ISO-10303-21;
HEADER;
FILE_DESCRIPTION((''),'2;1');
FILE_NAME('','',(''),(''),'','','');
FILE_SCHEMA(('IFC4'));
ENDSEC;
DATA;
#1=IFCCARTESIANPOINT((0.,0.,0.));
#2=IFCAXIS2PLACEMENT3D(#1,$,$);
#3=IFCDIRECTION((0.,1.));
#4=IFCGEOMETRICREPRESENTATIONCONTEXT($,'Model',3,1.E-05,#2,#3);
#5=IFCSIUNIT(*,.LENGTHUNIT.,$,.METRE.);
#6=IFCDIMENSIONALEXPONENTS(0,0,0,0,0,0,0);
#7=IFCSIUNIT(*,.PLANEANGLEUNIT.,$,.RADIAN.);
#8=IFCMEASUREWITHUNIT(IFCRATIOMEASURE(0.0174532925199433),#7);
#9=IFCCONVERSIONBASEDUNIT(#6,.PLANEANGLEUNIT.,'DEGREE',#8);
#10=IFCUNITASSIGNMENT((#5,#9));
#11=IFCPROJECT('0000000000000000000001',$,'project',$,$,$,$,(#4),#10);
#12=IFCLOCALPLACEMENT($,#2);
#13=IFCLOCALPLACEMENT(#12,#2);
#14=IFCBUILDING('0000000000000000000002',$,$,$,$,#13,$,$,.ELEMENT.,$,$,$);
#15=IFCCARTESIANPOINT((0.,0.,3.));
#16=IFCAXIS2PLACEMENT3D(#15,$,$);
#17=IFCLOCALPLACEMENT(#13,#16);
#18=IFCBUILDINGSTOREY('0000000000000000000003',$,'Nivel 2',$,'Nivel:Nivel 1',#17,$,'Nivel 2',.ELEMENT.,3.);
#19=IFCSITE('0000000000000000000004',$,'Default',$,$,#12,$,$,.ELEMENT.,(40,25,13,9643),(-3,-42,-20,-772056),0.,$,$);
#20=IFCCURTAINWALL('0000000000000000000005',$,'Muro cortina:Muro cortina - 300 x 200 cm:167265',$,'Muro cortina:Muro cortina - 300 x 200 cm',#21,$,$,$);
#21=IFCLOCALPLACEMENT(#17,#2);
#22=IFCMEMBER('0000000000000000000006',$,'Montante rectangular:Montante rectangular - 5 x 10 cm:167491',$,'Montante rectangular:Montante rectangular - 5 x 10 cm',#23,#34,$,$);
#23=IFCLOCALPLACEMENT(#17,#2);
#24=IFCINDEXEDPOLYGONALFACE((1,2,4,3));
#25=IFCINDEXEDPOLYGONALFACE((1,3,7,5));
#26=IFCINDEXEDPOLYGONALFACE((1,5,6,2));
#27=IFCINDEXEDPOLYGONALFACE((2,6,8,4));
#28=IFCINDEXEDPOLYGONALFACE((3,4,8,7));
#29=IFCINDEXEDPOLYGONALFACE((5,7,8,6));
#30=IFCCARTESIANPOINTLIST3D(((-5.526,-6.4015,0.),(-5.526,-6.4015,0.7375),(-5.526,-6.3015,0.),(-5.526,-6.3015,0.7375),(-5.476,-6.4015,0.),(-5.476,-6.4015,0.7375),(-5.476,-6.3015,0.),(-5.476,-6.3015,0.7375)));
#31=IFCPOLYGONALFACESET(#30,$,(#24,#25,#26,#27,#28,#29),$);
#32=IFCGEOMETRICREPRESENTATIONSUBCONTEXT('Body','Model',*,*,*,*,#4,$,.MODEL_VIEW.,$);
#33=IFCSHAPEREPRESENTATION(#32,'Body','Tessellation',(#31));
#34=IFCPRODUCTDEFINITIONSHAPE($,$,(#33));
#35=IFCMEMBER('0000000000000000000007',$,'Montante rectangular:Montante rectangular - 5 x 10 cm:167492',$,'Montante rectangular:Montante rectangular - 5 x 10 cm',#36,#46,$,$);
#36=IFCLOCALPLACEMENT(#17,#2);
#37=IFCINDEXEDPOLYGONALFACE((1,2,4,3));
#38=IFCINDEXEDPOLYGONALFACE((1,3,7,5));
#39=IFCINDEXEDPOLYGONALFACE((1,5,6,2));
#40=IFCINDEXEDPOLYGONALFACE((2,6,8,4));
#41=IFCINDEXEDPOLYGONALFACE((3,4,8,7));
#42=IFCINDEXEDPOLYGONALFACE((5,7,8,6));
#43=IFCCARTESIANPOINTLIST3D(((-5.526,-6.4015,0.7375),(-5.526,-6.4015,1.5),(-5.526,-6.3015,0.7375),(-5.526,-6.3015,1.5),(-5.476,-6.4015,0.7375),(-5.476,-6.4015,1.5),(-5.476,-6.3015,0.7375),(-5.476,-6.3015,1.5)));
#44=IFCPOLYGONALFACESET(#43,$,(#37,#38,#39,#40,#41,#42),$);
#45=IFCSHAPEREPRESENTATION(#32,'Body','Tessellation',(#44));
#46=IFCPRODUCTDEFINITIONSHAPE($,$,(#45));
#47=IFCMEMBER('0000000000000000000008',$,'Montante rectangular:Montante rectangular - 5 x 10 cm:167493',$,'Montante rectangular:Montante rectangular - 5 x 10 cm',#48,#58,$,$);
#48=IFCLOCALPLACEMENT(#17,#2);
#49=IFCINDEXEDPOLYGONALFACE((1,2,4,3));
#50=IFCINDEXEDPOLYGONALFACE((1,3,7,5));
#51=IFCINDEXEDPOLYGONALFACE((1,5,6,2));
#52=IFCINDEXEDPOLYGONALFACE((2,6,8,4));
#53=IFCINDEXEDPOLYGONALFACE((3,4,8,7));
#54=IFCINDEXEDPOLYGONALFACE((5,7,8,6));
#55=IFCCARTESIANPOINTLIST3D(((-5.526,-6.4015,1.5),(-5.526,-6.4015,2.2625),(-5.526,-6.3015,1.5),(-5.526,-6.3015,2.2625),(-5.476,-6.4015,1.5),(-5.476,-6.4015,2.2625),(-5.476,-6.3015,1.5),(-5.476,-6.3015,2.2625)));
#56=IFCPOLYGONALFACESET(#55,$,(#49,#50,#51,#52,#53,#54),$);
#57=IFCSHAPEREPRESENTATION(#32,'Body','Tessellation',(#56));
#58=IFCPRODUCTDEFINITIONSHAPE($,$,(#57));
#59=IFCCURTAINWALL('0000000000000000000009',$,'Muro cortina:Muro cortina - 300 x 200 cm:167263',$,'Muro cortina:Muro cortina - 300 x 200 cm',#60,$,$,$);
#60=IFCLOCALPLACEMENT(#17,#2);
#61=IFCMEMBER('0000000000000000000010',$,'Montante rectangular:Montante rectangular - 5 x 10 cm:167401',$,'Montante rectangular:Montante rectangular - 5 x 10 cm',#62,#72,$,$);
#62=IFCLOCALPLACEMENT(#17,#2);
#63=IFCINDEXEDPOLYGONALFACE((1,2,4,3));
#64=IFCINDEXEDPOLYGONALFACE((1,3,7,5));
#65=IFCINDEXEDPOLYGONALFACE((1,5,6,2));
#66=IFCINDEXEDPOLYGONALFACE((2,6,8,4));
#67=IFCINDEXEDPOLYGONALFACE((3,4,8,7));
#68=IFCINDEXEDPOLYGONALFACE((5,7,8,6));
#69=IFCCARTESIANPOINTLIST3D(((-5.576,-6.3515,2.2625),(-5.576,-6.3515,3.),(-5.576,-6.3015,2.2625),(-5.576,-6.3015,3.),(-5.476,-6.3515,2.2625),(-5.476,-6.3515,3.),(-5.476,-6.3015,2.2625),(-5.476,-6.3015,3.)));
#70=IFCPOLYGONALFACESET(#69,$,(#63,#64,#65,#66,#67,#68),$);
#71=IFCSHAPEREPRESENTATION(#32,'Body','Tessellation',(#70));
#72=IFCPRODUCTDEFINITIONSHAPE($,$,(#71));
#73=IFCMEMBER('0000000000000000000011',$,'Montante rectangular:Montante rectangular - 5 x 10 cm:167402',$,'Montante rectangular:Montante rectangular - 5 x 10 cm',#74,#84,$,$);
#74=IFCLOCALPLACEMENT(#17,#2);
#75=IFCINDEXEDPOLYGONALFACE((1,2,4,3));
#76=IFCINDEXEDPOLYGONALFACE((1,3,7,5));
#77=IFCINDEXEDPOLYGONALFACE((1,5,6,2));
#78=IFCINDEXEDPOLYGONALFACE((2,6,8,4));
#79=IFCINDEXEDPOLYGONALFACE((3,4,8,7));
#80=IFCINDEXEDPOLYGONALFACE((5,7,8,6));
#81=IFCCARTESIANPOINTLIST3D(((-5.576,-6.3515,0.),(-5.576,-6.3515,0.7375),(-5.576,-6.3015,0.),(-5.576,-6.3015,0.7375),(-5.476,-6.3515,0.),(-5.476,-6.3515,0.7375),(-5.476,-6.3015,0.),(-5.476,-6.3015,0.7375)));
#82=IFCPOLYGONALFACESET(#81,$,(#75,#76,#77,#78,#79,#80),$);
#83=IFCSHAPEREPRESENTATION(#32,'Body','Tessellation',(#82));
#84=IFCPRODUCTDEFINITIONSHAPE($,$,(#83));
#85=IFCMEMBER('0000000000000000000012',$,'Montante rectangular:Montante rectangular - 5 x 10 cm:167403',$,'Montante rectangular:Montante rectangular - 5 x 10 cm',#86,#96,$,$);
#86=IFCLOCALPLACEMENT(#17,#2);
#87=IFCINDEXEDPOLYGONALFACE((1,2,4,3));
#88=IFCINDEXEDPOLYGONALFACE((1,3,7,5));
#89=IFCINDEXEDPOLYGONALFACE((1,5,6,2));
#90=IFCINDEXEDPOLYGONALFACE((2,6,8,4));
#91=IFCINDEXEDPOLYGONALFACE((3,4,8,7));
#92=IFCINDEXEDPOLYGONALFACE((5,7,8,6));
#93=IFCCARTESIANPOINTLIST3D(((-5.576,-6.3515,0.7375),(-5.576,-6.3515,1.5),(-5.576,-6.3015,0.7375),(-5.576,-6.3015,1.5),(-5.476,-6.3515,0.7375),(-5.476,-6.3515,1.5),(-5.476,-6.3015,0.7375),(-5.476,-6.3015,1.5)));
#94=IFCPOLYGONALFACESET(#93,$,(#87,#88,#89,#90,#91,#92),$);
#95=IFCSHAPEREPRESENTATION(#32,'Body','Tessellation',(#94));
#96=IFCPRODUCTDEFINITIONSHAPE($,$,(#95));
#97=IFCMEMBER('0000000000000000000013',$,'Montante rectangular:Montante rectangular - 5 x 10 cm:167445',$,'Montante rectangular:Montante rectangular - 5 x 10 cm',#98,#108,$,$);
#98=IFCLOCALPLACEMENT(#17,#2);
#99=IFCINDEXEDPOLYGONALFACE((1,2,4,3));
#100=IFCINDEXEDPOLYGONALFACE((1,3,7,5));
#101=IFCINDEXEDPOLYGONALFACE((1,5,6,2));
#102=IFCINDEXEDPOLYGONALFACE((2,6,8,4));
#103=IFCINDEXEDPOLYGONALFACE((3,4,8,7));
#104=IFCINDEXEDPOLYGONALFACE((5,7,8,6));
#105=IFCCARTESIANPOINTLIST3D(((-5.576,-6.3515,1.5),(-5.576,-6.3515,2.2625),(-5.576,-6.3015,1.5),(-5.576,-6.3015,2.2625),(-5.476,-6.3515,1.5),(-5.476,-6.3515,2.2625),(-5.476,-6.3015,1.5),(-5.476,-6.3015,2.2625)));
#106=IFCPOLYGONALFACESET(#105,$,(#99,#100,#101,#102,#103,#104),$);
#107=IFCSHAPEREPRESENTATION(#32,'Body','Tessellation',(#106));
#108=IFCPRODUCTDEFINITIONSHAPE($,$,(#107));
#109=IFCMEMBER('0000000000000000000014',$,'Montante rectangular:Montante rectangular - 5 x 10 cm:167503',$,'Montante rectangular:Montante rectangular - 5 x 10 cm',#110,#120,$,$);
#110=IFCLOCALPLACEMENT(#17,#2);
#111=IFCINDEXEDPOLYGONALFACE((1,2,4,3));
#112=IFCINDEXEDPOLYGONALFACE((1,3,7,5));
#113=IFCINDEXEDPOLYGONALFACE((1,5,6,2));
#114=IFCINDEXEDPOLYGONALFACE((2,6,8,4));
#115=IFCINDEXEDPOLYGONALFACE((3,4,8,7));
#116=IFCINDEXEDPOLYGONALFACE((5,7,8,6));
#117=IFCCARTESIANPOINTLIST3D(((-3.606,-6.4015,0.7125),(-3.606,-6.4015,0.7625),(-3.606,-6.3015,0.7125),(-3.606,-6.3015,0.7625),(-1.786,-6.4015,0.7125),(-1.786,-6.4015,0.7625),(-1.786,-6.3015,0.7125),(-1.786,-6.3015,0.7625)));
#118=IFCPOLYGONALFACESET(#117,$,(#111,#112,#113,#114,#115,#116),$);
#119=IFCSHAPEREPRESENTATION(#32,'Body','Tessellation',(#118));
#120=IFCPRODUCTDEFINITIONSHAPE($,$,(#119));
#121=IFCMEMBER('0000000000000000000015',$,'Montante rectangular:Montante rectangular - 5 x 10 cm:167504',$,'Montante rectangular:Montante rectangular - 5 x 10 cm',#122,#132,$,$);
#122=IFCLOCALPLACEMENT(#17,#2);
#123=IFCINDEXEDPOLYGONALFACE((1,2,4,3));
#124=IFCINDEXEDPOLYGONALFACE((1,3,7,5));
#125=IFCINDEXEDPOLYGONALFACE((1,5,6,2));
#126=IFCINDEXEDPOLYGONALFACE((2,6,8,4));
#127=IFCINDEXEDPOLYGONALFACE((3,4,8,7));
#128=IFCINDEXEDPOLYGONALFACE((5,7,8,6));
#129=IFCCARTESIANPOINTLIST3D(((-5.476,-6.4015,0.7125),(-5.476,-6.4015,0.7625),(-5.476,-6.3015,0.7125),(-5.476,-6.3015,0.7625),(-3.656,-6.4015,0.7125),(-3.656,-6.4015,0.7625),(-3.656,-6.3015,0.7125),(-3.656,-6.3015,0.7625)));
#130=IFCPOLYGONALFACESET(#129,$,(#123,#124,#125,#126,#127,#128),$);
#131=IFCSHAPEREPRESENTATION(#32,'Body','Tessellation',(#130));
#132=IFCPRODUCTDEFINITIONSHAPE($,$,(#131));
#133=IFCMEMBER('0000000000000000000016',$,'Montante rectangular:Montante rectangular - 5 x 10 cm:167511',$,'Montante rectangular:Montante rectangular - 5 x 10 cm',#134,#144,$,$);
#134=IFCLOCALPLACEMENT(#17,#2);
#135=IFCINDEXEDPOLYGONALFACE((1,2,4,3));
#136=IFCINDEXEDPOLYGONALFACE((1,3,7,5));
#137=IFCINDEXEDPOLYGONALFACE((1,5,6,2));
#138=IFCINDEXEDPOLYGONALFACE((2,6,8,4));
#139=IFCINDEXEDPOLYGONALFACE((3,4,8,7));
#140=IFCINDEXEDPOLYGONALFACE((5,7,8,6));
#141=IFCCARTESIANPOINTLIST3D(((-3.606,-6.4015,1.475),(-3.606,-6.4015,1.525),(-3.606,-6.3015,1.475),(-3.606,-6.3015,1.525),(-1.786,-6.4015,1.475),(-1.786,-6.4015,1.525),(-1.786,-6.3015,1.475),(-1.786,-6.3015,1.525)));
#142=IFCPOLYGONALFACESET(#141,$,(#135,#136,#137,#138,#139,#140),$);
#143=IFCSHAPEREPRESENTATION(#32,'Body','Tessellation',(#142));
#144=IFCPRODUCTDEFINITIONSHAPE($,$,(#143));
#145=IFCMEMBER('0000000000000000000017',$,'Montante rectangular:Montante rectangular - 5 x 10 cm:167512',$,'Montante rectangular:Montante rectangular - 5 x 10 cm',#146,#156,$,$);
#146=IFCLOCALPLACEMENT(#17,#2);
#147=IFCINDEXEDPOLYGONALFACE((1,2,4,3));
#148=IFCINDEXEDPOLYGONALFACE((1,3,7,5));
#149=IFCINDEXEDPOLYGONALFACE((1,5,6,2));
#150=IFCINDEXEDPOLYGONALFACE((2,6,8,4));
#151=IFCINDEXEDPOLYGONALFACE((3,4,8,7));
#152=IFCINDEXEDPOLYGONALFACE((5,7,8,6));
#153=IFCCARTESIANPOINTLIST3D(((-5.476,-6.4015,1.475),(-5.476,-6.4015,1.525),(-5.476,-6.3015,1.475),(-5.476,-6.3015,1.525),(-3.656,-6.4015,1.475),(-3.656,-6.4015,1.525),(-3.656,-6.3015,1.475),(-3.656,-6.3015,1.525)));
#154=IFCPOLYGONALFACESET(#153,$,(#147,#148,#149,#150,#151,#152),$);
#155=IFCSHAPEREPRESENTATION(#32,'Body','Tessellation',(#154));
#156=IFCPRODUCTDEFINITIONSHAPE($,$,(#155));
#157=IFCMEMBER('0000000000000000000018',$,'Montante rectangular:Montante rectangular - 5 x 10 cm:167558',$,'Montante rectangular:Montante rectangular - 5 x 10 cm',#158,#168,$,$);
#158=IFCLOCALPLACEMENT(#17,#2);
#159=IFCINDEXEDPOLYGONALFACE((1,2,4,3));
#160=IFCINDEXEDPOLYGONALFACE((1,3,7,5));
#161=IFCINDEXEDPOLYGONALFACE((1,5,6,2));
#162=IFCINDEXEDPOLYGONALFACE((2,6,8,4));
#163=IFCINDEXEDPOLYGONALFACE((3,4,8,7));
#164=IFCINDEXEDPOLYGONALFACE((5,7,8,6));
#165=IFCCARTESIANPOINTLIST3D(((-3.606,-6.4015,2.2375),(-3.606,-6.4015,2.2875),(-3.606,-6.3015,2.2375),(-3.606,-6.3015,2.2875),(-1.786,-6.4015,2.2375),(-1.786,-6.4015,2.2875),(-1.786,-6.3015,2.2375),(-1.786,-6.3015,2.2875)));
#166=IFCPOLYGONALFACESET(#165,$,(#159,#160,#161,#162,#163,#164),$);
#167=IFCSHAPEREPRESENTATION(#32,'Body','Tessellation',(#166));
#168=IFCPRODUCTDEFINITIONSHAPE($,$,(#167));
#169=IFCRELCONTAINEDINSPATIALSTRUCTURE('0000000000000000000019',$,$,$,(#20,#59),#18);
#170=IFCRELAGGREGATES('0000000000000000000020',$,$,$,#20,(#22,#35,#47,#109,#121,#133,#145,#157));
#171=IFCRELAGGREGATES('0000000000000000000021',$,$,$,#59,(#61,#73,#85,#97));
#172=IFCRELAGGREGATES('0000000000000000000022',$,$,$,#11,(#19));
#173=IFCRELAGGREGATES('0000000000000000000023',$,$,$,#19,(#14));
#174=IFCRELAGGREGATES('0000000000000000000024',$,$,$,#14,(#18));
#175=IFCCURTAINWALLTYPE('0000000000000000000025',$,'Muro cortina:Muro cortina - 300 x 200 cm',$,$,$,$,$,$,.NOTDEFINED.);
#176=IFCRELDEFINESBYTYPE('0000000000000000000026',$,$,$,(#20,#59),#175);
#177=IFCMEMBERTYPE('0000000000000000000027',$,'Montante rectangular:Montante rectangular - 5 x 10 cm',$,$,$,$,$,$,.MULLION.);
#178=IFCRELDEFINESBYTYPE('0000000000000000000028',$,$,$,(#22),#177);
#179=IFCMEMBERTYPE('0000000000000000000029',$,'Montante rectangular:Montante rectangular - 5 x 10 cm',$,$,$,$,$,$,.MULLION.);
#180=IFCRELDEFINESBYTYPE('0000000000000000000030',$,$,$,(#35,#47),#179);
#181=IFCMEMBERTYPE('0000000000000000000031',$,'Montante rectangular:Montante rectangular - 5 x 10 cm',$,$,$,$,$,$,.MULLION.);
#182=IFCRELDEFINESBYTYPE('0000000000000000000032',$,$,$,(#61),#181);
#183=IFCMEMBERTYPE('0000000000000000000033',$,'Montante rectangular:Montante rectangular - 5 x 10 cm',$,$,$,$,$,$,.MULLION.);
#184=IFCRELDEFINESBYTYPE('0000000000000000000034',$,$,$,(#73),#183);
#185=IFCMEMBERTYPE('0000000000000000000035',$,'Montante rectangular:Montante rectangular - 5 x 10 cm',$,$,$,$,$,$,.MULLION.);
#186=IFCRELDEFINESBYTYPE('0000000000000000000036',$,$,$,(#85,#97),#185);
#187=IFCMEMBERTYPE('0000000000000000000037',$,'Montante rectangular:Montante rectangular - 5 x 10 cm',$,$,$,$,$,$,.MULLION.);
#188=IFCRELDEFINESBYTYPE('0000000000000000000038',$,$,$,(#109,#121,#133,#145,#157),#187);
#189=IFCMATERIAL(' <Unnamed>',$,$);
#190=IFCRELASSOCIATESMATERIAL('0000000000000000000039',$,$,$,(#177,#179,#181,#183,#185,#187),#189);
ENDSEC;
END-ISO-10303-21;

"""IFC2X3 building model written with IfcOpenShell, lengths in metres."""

from ifc_helpers import new_model, entity, si_unit, converted_unit, direction, frame, origin, origin_2d_with_axis, place, context, subcontext, project, spatial, rectangle, extrude, source, transform, mapped, material, type_object, type_shapes, element, aggregate, save


model = new_model("IFC2X3")

# Units and contexts
model_context = context("Model", 3, precision=1e-05, world=origin(), true_north=direction((0.0, 1.0)))
body_context = subcontext(model_context, "Body", "Model", "MODEL_VIEW")
ifc_project = project(units=[si_unit("LENGTHUNIT", "METRE"), converted_unit("PLANEANGLEUNIT", "DEGREE", entity("IfcRatioMeasure", 0.0174532925199433), si_unit("PLANEANGLEUNIT", "RADIAN"), dimensions=[0, 0, 0, 0, 0, 0, 0])], contexts=[model_context])

# Site, building, storey
site_placement = place(None, origin())
site = spatial("IfcSite", under=ifc_project, at=site_placement, Name="Default", CompositionType="ELEMENT", RefLatitude=(40, 25, 13, 9643), RefLongitude=(-3, -42, -20, -772056), RefElevation=0.0)
building_placement = place(site_placement, origin())
building = spatial("IfcBuilding", under=site, at=building_placement, CompositionType="ELEMENT")
storey_placement = place(building_placement, frame((0.0, 0.0, 3.0)))
storey = spatial("IfcBuildingStorey", under=building, at=storey_placement, Name="Nivel 2", ObjectType="Nivel:Nivel 1", LongName="Nivel 2", CompositionType="ELEMENT", Elevation=3.0)

# Curtain walls, members
curtain_wall_type = type_object("IfcCurtainWallType", Name="Muro cortina:Muro cortina - 300 x 200 cm", PredefinedType="NOTDEFINED")
curtain_wall_1_placement = place(storey_placement, frame((0.0, 0.0, -3.0)))
curtain_wall_1 = element("IfcCurtainWall", 1, at=curtain_wall_1_placement, inside=storey, type_object=curtain_wall_type, Name="Muro cortina:Muro cortina - 300 x 200 cm:167265", ObjectType="Muro cortina:Muro cortina - 300 x 200 cm")
ifc_material_1 = material(Name=" <Unnamed>")
member_type_1 = type_object("IfcMemberType", Name="Montante rectangular:Montante rectangular - 5 x 10 cm", PredefinedType="MULLION", material=ifc_material_1)
shared_shape_1 = source(origin(), body_context, "Body", "SweptSolid", [
    extrude(rectangle(XDim=0.1, YDim=0.05, at=origin_2d_with_axis()), frame((-0.025, 0.0, -0.7375), z_axis=(0.0, 0.0, 1.0), x_axis=(0.0, -1.0, 0.0)), (0.0, 0.0, 1.0), 0.7375),
])
type_shapes(member_type_1, [shared_shape_1])
member_1_placement = place(storey_placement, frame((-5.526, -6.3515, 0.0), z_axis=(0.0, 0.0, -1.0), x_axis=(-1.0, 0.0, 0.0)))
member_1 = element("IfcMember", 2, at=member_1_placement, type_object=member_type_1, Name="Montante rectangular:Montante rectangular - 5 x 10 cm:167491", ObjectType="Montante rectangular:Montante rectangular - 5 x 10 cm", context=body_context, shape_type="MappedRepresentation", body=[
    mapped(shared_shape_1, transform((0.0, 0.0, 0.0), scale=1.0)),
])
member_type_2 = type_object("IfcMemberType", Name="Montante rectangular:Montante rectangular - 5 x 10 cm", PredefinedType="MULLION", material=ifc_material_1)
shared_shape_2 = source(origin(), body_context, "Body", "SweptSolid", [
    extrude(rectangle(XDim=0.1, YDim=0.05, at=origin_2d_with_axis()), frame((-0.025, 0.0, -0.7625), z_axis=(0.0, 0.0, 1.0), x_axis=(0.0, -1.0, 0.0)), (0.0, 0.0, 1.0), 0.7625),
])
type_shapes(member_type_2, [shared_shape_2])
member_2_placement = place(storey_placement, frame((-5.526, -6.3515, 0.7375), z_axis=(0.0, 0.0, -1.0), x_axis=(-1.0, 0.0, 0.0)))
member_2 = element("IfcMember", 3, at=member_2_placement, type_object=member_type_2, Name="Montante rectangular:Montante rectangular - 5 x 10 cm:167492", ObjectType="Montante rectangular:Montante rectangular - 5 x 10 cm", context=body_context, shape_type="MappedRepresentation", body=[
    mapped(shared_shape_2, transform((0.0, 0.0, 0.0), scale=1.0)),
])
member_3_placement = place(storey_placement, frame((-5.526, -6.3515, 1.5), z_axis=(0.0, 0.0, -1.0), x_axis=(-1.0, 0.0, 0.0)))
member_3 = element("IfcMember", 4, at=member_3_placement, type_object=member_type_2, Name="Montante rectangular:Montante rectangular - 5 x 10 cm:167493", ObjectType="Montante rectangular:Montante rectangular - 5 x 10 cm", context=body_context, shape_type="MappedRepresentation", body=[
    mapped(shared_shape_2, transform((0.0, 0.0, 0.0), scale=1.0)),
])
curtain_wall_2_placement = place(storey_placement, frame((0.0, 0.0, -3.0)))
curtain_wall_2 = element("IfcCurtainWall", 5, at=curtain_wall_2_placement, inside=storey, type_object=curtain_wall_type, Name="Muro cortina:Muro cortina - 300 x 200 cm:167263", ObjectType="Muro cortina:Muro cortina - 300 x 200 cm")
member_type_3 = type_object("IfcMemberType", Name="Montante rectangular:Montante rectangular - 5 x 10 cm", PredefinedType="MULLION", material=ifc_material_1)
shared_shape_3 = source(origin(), body_context, "Body", "SweptSolid", [
    extrude(rectangle(XDim=0.1, YDim=0.05, at=origin_2d_with_axis()), frame((-0.025, 0.0, -0.7375), z_axis=(0.0, 0.0, 1.0), x_axis=(0.0, -1.0, 0.0)), (0.0, 0.0, 1.0), 0.7375),
])
type_shapes(member_type_3, [shared_shape_3])
member_4_placement = place(storey_placement, frame((-5.526, -6.3515, 3.0), z_axis=(0.0, 0.0, 1.0), x_axis=(0.0, -1.0, 0.0)))
member_4 = element("IfcMember", 6, at=member_4_placement, type_object=member_type_3, Name="Montante rectangular:Montante rectangular - 5 x 10 cm:167401", ObjectType="Montante rectangular:Montante rectangular - 5 x 10 cm", context=body_context, shape_type="MappedRepresentation", body=[
    mapped(shared_shape_3, transform((0.0, 0.0, 0.0), scale=1.0)),
])
member_type_4 = type_object("IfcMemberType", Name="Montante rectangular:Montante rectangular - 5 x 10 cm", PredefinedType="MULLION", material=ifc_material_1)
shared_shape_4 = source(origin(), body_context, "Body", "SweptSolid", [
    extrude(rectangle(XDim=0.1, YDim=0.05, at=origin_2d_with_axis()), frame((-0.025, 0.0, -0.7375), z_axis=(0.0, 0.0, 1.0), x_axis=(0.0, -1.0, 0.0)), (0.0, 0.0, 1.0), 0.7375),
])
type_shapes(member_type_4, [shared_shape_4])
member_5_placement = place(storey_placement, frame((-5.526, -6.3515, 0.7375), z_axis=(0.0, 0.0, 1.0), x_axis=(0.0, -1.0, 0.0)))
member_5 = element("IfcMember", 7, at=member_5_placement, type_object=member_type_4, Name="Montante rectangular:Montante rectangular - 5 x 10 cm:167402", ObjectType="Montante rectangular:Montante rectangular - 5 x 10 cm", context=body_context, shape_type="MappedRepresentation", body=[
    mapped(shared_shape_4, transform((0.0, 0.0, 0.0), scale=1.0)),
])
member_type_5 = type_object("IfcMemberType", Name="Montante rectangular:Montante rectangular - 5 x 10 cm", PredefinedType="MULLION", material=ifc_material_1)
shared_shape_5 = source(origin(), body_context, "Body", "SweptSolid", [
    extrude(rectangle(XDim=0.1, YDim=0.05, at=origin_2d_with_axis()), frame((-0.025, 0.0, -0.7625), z_axis=(0.0, 0.0, 1.0), x_axis=(0.0, -1.0, 0.0)), (0.0, 0.0, 1.0), 0.7625),
])
type_shapes(member_type_5, [shared_shape_5])
member_6_placement = place(storey_placement, frame((-5.526, -6.3515, 1.5), z_axis=(0.0, 0.0, 1.0), x_axis=(0.0, -1.0, 0.0)))
member_6 = element("IfcMember", 8, at=member_6_placement, type_object=member_type_5, Name="Montante rectangular:Montante rectangular - 5 x 10 cm:167403", ObjectType="Montante rectangular:Montante rectangular - 5 x 10 cm", context=body_context, shape_type="MappedRepresentation", body=[
    mapped(shared_shape_5, transform((0.0, 0.0, 0.0), scale=1.0)),
])
member_7_placement = place(storey_placement, frame((-5.526, -6.3515, 2.2625), z_axis=(0.0, 0.0, 1.0), x_axis=(0.0, -1.0, 0.0)))
member_7 = element("IfcMember", 9, at=member_7_placement, type_object=member_type_5, Name="Montante rectangular:Montante rectangular - 5 x 10 cm:167445", ObjectType="Montante rectangular:Montante rectangular - 5 x 10 cm", context=body_context, shape_type="MappedRepresentation", body=[
    mapped(shared_shape_5, transform((0.0, 0.0, 0.0), scale=1.0)),
])

# Members
member_type_6 = type_object("IfcMemberType", Name="Montante rectangular:Montante rectangular - 5 x 10 cm", PredefinedType="MULLION", material=ifc_material_1)
shared_shape_6 = source(origin(), body_context, "Body", "SweptSolid", [
    extrude(rectangle(XDim=0.1, YDim=0.05, at=origin_2d_with_axis()), frame((0.0, 0.0, -1.82), z_axis=(0.0, 0.0, 1.0), x_axis=(0.0, -1.0, 0.0)), (0.0, 0.0, 1.0), 1.82),
])
type_shapes(member_type_6, [shared_shape_6])
member_8_placement = place(storey_placement, frame((-3.606, -6.3515, 0.7375), z_axis=(-1.0, 0.0, 0.0), x_axis=(0.0, 0.0, 1.0)))
member_8 = element("IfcMember", 10, at=member_8_placement, type_object=member_type_6, Name="Montante rectangular:Montante rectangular - 5 x 10 cm:167503", ObjectType="Montante rectangular:Montante rectangular - 5 x 10 cm", context=body_context, shape_type="MappedRepresentation", body=[
    mapped(shared_shape_6, transform((0.0, 0.0, 0.0), scale=1.0)),
])
member_9_placement = place(storey_placement, frame((-5.476, -6.3515, 0.7375), z_axis=(-1.0, 0.0, 0.0), x_axis=(0.0, 0.0, 1.0)))
member_9 = element("IfcMember", 11, at=member_9_placement, type_object=member_type_6, Name="Montante rectangular:Montante rectangular - 5 x 10 cm:167504", ObjectType="Montante rectangular:Montante rectangular - 5 x 10 cm", context=body_context, shape_type="MappedRepresentation", body=[
    mapped(shared_shape_6, transform((0.0, 0.0, 0.0), scale=1.0)),
])
member_10_placement = place(storey_placement, frame((-3.606, -6.3515, 1.5), z_axis=(-1.0, 0.0, 0.0), x_axis=(0.0, 0.0, 1.0)))
member_10 = element("IfcMember", 12, at=member_10_placement, type_object=member_type_6, Name="Montante rectangular:Montante rectangular - 5 x 10 cm:167511", ObjectType="Montante rectangular:Montante rectangular - 5 x 10 cm", context=body_context, shape_type="MappedRepresentation", body=[
    mapped(shared_shape_6, transform((0.0, 0.0, 0.0), scale=1.0)),
])
member_11_placement = place(storey_placement, frame((-5.476, -6.3515, 1.5), z_axis=(-1.0, 0.0, 0.0), x_axis=(0.0, 0.0, 1.0)))
member_11 = element("IfcMember", 13, at=member_11_placement, type_object=member_type_6, Name="Montante rectangular:Montante rectangular - 5 x 10 cm:167512", ObjectType="Montante rectangular:Montante rectangular - 5 x 10 cm", context=body_context, shape_type="MappedRepresentation", body=[
    mapped(shared_shape_6, transform((0.0, 0.0, 0.0), scale=1.0)),
])
member_12_placement = place(storey_placement, frame((-3.606, -6.3515, 2.2625), z_axis=(-1.0, 0.0, 0.0), x_axis=(0.0, 0.0, 1.0)))
member_12 = element("IfcMember", 14, at=member_12_placement, type_object=member_type_6, Name="Montante rectangular:Montante rectangular - 5 x 10 cm:167558", ObjectType="Montante rectangular:Montante rectangular - 5 x 10 cm", context=body_context, shape_type="MappedRepresentation", body=[
    mapped(shared_shape_6, transform((0.0, 0.0, 0.0), scale=1.0)),
])

aggregate(curtain_wall_1, [member_1, member_2, member_3, member_8, member_9, member_10, member_11, member_12])
aggregate(curtain_wall_2, [member_4, member_5, member_6, member_7])

save(model, "model.ifc")
